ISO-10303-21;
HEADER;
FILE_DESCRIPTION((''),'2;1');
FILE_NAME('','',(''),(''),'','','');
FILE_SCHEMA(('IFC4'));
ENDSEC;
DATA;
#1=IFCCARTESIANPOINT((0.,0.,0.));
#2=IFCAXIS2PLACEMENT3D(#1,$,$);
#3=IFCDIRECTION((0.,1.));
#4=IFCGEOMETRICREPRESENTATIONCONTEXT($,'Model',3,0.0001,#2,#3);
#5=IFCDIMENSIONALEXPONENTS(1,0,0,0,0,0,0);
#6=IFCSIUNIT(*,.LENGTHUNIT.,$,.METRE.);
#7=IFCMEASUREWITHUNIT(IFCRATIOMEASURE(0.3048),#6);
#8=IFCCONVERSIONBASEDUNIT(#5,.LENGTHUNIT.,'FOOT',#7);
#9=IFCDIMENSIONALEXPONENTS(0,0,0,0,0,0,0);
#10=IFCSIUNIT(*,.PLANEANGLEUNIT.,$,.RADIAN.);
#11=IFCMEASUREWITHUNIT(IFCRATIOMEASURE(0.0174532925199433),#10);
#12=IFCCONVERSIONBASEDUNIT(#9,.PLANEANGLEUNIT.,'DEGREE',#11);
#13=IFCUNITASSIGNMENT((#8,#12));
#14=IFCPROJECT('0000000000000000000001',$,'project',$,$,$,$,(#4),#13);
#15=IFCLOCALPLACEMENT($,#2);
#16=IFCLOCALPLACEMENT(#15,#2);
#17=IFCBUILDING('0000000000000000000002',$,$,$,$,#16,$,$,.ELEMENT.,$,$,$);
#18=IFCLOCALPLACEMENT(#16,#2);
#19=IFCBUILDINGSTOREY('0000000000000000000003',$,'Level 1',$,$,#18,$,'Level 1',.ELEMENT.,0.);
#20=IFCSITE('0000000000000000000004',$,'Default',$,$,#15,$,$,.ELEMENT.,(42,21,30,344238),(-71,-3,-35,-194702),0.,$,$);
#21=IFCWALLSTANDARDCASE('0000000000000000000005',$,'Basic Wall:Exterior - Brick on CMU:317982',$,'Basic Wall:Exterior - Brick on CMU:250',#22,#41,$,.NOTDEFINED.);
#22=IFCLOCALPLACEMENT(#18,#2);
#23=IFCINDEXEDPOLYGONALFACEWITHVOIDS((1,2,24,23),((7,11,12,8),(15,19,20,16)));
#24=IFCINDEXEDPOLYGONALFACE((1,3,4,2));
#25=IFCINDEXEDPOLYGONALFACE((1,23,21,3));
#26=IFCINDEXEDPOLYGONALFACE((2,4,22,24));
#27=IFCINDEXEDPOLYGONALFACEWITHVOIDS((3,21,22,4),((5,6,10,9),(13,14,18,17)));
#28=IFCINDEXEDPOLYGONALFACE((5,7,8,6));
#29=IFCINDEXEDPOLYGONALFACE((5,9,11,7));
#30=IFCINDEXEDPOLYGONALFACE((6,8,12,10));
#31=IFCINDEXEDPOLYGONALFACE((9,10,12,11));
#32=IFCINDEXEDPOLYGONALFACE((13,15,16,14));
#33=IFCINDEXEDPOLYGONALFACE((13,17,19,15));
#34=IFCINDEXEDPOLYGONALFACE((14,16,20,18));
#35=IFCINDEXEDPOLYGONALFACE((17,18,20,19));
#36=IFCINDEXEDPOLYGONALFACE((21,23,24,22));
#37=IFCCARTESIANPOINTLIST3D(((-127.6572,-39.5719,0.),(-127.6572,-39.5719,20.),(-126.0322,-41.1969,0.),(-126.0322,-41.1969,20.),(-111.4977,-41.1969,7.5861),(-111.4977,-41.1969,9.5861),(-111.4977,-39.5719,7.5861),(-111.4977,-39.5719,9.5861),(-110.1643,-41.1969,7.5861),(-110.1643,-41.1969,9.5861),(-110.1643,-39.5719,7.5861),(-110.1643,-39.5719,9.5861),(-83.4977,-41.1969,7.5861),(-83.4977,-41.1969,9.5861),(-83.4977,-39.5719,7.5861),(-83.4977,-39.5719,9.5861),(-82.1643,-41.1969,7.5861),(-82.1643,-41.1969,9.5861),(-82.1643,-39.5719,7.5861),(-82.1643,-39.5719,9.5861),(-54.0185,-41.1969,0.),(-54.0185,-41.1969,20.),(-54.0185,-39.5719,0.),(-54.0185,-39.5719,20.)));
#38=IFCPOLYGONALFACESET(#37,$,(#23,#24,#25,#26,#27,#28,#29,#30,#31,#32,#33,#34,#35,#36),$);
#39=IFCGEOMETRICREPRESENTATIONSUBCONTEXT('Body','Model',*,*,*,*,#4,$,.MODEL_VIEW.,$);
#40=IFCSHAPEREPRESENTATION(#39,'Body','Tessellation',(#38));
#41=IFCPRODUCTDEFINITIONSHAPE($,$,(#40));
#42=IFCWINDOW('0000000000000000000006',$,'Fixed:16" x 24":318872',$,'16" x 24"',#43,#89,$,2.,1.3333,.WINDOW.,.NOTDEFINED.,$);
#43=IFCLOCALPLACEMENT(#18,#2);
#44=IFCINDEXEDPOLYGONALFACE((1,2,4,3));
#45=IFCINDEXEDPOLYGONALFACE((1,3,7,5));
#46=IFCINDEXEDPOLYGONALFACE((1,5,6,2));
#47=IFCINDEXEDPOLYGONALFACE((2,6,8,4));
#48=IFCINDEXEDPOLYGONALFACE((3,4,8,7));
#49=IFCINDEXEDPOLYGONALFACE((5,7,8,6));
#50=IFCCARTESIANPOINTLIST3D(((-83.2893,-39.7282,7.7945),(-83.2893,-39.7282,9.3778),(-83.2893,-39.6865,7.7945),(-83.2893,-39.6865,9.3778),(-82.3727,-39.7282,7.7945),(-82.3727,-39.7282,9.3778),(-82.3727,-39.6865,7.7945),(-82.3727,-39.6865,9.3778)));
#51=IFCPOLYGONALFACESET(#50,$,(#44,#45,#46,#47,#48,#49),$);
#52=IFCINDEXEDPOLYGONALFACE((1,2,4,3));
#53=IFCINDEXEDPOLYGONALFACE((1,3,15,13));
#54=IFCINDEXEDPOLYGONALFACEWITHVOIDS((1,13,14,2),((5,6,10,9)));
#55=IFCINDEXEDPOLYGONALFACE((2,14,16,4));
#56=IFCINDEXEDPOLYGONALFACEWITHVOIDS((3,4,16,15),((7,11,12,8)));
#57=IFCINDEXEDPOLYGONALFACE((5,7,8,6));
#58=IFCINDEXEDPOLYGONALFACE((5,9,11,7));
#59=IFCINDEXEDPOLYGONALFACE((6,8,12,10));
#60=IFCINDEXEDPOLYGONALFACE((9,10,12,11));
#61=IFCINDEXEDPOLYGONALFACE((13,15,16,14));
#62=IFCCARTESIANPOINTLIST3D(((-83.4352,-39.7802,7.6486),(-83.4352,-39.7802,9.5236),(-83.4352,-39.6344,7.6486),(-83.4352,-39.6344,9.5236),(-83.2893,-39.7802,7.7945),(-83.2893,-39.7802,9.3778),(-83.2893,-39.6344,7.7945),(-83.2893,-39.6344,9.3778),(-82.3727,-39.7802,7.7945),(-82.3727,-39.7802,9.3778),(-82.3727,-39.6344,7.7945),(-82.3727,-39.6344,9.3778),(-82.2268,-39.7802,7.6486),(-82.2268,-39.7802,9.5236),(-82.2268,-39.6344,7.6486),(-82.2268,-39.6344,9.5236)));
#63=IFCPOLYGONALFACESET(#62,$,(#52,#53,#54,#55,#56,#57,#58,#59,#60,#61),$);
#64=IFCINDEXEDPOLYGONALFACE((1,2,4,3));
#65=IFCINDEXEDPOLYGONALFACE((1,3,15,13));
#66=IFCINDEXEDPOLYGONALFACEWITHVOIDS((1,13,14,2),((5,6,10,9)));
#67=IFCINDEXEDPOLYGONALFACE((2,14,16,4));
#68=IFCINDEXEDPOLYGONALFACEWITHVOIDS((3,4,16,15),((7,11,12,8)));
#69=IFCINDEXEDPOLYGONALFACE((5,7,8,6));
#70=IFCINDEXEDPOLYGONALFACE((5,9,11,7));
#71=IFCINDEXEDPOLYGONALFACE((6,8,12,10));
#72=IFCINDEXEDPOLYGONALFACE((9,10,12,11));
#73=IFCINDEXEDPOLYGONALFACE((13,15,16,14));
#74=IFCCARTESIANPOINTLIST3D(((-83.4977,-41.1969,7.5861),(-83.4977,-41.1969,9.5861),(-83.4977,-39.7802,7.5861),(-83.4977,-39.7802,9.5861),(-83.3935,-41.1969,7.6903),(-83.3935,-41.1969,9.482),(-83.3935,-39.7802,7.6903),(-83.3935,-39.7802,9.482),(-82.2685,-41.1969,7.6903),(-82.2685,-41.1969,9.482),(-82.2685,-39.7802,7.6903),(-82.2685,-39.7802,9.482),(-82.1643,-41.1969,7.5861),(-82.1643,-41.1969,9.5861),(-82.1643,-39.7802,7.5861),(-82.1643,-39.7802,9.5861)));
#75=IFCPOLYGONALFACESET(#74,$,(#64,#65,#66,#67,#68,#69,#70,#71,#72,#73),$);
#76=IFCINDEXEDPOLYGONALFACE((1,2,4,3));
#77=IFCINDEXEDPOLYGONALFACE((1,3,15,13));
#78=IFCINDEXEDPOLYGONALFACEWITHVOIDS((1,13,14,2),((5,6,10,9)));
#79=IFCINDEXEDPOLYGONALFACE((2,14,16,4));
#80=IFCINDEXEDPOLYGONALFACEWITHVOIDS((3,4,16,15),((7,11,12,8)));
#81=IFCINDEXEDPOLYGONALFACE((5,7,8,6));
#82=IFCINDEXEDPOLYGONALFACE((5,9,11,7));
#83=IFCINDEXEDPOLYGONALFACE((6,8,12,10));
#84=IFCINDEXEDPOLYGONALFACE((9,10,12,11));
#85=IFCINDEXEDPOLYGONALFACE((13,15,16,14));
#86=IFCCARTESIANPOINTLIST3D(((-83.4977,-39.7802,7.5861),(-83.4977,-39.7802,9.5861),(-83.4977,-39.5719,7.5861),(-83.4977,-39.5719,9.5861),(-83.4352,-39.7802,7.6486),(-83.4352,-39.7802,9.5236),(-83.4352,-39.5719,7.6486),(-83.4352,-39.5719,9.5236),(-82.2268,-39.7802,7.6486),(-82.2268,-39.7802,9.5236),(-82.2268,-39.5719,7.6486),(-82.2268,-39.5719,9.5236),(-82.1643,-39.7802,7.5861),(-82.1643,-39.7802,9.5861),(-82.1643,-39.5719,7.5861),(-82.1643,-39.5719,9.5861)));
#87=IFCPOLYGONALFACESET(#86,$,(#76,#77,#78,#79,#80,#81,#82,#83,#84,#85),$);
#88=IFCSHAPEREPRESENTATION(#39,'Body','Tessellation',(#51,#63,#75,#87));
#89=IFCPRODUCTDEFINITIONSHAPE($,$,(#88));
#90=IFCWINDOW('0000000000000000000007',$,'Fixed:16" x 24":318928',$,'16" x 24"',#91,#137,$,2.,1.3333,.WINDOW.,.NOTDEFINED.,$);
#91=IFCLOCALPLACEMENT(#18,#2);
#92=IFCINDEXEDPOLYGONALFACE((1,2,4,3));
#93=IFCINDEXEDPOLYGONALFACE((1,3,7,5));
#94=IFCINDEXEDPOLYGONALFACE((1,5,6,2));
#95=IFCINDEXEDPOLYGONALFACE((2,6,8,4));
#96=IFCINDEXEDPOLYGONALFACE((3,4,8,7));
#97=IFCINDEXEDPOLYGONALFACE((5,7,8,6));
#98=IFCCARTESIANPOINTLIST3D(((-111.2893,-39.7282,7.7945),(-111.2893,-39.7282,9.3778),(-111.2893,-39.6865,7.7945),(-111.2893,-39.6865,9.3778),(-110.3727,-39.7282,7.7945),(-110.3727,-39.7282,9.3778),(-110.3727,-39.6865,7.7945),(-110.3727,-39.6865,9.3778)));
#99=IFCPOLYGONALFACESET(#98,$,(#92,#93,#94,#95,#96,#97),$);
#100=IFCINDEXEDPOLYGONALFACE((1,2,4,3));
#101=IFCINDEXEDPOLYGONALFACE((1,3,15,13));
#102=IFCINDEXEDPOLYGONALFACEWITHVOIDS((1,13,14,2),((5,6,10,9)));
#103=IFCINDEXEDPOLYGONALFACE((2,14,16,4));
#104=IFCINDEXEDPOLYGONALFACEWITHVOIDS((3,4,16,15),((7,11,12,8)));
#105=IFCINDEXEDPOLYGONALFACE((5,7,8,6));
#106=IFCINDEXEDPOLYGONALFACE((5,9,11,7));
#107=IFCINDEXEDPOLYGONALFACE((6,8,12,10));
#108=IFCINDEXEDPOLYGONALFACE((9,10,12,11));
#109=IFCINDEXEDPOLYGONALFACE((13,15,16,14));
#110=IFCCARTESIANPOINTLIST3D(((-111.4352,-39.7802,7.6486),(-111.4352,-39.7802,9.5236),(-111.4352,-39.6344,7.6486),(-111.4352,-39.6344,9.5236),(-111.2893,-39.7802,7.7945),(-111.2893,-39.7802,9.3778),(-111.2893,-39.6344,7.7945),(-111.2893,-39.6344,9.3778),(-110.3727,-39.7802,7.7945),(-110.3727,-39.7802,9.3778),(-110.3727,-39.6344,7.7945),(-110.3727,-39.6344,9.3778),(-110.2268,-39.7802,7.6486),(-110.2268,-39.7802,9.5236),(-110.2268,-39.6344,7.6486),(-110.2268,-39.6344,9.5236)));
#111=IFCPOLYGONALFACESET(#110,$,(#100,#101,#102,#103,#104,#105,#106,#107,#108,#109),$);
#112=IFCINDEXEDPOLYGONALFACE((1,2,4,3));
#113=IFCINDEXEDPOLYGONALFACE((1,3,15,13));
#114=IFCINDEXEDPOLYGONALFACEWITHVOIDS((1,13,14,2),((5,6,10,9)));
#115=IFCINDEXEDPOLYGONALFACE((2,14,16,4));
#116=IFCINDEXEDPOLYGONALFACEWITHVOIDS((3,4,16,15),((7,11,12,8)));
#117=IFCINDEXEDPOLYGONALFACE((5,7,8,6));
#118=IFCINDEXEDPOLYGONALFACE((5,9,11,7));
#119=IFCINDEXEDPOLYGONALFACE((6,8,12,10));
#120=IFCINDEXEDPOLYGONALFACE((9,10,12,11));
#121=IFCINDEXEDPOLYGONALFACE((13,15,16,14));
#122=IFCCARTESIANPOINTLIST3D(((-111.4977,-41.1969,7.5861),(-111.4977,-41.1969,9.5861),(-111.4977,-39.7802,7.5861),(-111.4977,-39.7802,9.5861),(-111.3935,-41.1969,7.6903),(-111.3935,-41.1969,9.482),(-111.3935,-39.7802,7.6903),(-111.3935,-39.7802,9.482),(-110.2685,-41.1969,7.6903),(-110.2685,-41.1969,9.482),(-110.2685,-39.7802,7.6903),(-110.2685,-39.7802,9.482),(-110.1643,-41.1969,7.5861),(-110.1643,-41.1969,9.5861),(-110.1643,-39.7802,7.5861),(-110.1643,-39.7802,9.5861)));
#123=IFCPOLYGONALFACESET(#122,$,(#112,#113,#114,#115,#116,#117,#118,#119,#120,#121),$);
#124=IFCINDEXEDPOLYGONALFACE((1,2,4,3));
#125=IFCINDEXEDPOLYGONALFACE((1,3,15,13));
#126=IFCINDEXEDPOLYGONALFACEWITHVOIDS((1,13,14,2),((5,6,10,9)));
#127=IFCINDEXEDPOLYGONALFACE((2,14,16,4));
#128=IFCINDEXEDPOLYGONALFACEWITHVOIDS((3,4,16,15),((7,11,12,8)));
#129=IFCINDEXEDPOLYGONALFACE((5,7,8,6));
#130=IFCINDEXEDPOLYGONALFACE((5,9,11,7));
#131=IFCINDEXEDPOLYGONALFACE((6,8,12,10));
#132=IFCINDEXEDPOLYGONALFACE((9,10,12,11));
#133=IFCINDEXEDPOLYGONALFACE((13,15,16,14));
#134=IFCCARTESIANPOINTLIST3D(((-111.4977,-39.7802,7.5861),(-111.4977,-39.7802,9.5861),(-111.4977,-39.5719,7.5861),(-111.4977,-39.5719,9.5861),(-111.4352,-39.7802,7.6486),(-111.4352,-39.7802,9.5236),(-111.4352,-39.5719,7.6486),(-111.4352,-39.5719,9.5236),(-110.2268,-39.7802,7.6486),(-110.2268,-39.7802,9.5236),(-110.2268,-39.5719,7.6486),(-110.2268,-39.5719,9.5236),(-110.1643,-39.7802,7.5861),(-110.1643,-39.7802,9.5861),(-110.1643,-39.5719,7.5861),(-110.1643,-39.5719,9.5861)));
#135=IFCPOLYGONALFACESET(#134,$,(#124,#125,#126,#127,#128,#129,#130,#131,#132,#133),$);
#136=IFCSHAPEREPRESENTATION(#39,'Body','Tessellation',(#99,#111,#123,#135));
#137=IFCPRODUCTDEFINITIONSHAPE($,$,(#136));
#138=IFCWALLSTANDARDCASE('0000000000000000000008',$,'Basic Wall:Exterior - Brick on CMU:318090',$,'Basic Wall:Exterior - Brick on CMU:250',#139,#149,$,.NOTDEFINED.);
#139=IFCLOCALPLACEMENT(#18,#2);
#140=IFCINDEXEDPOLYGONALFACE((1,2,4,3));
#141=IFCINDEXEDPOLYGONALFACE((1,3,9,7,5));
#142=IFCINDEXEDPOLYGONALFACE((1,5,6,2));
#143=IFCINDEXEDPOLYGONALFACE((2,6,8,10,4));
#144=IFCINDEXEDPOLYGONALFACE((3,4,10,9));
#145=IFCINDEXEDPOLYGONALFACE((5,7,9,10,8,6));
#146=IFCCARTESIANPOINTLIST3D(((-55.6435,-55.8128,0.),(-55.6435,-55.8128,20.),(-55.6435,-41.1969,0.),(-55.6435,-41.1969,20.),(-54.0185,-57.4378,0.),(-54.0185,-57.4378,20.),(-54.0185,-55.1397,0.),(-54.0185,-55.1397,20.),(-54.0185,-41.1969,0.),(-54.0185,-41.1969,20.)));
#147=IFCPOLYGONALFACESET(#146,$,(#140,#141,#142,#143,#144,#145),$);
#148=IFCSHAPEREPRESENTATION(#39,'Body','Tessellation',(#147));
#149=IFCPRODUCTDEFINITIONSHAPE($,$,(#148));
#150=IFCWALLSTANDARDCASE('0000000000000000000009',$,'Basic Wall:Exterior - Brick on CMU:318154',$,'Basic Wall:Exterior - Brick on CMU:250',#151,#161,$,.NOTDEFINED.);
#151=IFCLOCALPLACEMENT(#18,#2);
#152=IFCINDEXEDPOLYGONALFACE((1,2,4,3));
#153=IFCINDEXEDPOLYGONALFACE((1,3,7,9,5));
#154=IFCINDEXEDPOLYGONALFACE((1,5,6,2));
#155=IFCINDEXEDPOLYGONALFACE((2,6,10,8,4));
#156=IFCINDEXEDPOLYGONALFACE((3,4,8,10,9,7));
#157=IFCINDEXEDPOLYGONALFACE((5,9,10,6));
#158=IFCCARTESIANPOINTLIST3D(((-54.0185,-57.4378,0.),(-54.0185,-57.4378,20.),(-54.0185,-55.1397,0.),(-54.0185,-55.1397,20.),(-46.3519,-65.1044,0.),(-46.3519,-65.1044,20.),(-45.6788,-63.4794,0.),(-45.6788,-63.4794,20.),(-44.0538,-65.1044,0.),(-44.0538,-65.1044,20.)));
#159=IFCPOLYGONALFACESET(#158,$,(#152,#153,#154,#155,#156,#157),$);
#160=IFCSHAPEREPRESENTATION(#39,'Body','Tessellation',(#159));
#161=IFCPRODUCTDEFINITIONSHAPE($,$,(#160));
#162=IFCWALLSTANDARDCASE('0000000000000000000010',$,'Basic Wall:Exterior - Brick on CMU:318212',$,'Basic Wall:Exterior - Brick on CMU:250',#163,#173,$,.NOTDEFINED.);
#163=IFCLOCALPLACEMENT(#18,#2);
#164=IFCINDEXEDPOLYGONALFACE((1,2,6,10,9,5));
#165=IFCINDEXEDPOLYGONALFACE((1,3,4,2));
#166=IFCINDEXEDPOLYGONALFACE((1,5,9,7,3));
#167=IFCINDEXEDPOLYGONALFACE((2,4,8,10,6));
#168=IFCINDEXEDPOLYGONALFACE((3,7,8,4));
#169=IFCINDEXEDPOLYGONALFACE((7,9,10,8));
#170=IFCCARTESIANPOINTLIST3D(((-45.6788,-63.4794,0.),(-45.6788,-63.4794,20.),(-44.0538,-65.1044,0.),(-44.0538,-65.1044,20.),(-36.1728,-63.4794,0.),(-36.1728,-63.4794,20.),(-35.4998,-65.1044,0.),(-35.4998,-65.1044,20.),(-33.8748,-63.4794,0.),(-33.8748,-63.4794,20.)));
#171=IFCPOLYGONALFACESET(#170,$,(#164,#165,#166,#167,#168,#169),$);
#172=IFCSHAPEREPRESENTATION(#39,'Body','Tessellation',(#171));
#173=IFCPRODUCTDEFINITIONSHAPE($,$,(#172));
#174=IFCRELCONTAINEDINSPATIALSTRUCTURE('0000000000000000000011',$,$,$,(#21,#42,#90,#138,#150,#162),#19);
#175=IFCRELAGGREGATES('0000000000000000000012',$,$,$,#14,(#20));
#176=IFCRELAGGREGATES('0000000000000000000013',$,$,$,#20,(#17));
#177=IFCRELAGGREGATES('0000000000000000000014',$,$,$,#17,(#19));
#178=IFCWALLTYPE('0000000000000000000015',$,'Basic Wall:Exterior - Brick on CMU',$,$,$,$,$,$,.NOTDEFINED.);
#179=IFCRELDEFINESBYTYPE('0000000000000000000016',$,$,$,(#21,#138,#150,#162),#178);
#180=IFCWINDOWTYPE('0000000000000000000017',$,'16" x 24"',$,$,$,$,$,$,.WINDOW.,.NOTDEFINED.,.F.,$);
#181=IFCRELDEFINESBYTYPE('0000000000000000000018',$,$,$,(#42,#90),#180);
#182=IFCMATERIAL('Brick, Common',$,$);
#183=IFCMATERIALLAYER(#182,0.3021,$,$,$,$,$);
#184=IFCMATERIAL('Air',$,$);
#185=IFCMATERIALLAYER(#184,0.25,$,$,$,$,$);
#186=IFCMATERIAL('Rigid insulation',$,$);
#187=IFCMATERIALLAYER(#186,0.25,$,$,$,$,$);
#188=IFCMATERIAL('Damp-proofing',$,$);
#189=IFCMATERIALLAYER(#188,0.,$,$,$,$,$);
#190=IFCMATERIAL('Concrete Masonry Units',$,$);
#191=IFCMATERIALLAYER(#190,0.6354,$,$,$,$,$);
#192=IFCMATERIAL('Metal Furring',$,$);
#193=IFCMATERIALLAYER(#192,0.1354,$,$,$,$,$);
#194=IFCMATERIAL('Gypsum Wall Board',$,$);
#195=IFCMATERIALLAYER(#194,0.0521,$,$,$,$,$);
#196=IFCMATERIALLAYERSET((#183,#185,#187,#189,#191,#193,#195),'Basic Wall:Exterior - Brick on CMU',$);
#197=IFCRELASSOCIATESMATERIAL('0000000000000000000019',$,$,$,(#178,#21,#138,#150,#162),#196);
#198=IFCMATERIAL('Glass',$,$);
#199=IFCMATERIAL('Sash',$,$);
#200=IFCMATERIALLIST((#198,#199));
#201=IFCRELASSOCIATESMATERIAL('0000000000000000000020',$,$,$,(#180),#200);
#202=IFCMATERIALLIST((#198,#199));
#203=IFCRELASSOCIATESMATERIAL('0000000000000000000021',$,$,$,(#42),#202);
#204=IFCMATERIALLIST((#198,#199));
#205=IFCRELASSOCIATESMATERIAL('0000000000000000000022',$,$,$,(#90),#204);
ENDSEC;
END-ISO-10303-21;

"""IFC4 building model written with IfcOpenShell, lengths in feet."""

from ifc_helpers import new_model, entity, si_unit, converted_unit, direction, frame, frame_2d, origin, place, context, subcontext, project, spatial, polyline, rectangle, outline, extrude, source, transform, mapped, material, material_list, layer, layer_set, layer_usage, type_object, type_shapes, element, fill, save


model = new_model("IFC4")

# Units and contexts
model_context = context("Model", 3, precision=0.0001, world=origin(), true_north=direction((0.0, 1.0)))
body_context = subcontext(model_context, "Body", "Model", "MODEL_VIEW")
ifc_project = project(units=[converted_unit("LENGTHUNIT", "FOOT", entity("IfcRatioMeasure", 0.3048), si_unit("LENGTHUNIT", "METRE"), dimensions=[1, 0, 0, 0, 0, 0, 0]), converted_unit("PLANEANGLEUNIT", "DEGREE", entity("IfcRatioMeasure", 0.0174532925199433), si_unit("PLANEANGLEUNIT", "RADIAN"), dimensions=[0, 0, 0, 0, 0, 0, 0])], contexts=[model_context])

# Site, building, storey
site_placement = place(None, origin())
site = spatial("IfcSite", under=ifc_project, at=site_placement, Name="Default", CompositionType="ELEMENT", RefLatitude=(42, 21, 30, 344238), RefLongitude=(-71, -3, -35, -194702), RefElevation=0.0)
building_placement = place(site_placement, origin())
building = spatial("IfcBuilding", under=site, at=building_placement, CompositionType="ELEMENT")
storey_placement = place(building_placement, origin())
storey = spatial("IfcBuildingStorey", under=building, at=storey_placement, Name="Level 1", LongName="Level 1", CompositionType="ELEMENT", Elevation=0.0)

# Shared definitions
ifc_material_1 = material(Name="Brick, Common")
ifc_layer_1 = layer(ifc_material_1, 0.3021)
ifc_material_2 = material(Name="Air")
ifc_layer_2 = layer(ifc_material_2, 0.25)
ifc_material_3 = material(Name="Rigid insulation")
ifc_layer_3 = layer(ifc_material_3, 0.25)
ifc_material_4 = material(Name="Damp-proofing")
ifc_layer_4 = layer(ifc_material_4, 0.0)
ifc_material_5 = material(Name="Concrete Masonry Units")
ifc_layer_5 = layer(ifc_material_5, 0.6354)
ifc_material_6 = material(Name="Metal Furring")
ifc_layer_6 = layer(ifc_material_6, 0.1354)
ifc_material_7 = material(Name="Gypsum Wall Board")
ifc_layer_7 = layer(ifc_material_7, 0.0521)
ifc_layer_set = layer_set([ifc_layer_1, ifc_layer_2, ifc_layer_3, ifc_layer_4, ifc_layer_5, ifc_layer_6, ifc_layer_7], Name="Basic Wall:Exterior - Brick on CMU")
wall_type = type_object("IfcWallType", Name="Basic Wall:Exterior - Brick on CMU", PredefinedType="NOTDEFINED", material=ifc_layer_set)
ifc_material_8 = material(Name="Glass")
ifc_material_9 = material(Name="Sash")
ifc_material_list_1 = material_list([ifc_material_8, ifc_material_9])
window_type = type_object("IfcWindowType", Name="16\" x 24\"", ParameterTakesPrecedence=False, PartitioningType="NOTDEFINED", PredefinedType="WINDOW", material=ifc_material_list_1)
shared_shape_1 = source(origin(), body_context, "Body", "SweptSolid", [
    extrude(rectangle(XDim=0.0417, YDim=0.9167, at=frame_2d((0.0, 0.0), x_axis=(1.0, 0.0))), frame((0.6667, 1.4896, 0.2083), z_axis=(0.0, 0.0, 1.0), x_axis=(0.0, 1.0, 0.0)), (0.0, 0.0, 1.0), 1.5833),
    extrude(outline(polyline([(-0.6042, -0.9375), (0.6042, -0.9375), (0.6042, 0.9375), (-0.6042, 0.9375), (-0.6042, -0.9375)]), holes=[polyline([(-0.4583, -0.7917), (-0.4583, 0.7917), (0.4583, 0.7917), (0.4583, -0.7917), (-0.4583, -0.7917)])]), frame((0.6667, 1.4167, 1.0), z_axis=(0.0, 1.0, 0.0), x_axis=(1.0, 0.0, 0.0)), (0.0, 0.0, 1.0), 0.1458),
    extrude(outline(polyline([(-0.6667, -1.0), (0.6667, -1.0), (0.6667, 1.0), (-0.6667, 1.0), (-0.6667, -1.0)]), holes=[polyline([(-0.5625, -0.8958), (-0.5625, 0.8958), (0.5625, 0.8958), (0.5625, -0.8958), (-0.5625, -0.8958)])]), frame((0.6667, 0.0, 1.0), z_axis=(0.0, 1.0, 0.0), x_axis=(1.0, 0.0, 0.0)), (0.0, 0.0, 1.0), 1.4167),
    extrude(outline(polyline([(-1.0, -0.6667), (1.0, -0.6667), (1.0, 0.6667), (-1.0, 0.6667), (-1.0, -0.6667)]), holes=[polyline([(-0.9375, -0.6042), (-0.9375, 0.6042), (0.9375, 0.6042), (0.9375, -0.6042), (-0.9375, -0.6042)])]), frame((0.6667, 1.4167, 1.0), z_axis=(0.0, 1.0, 0.0), x_axis=(0.0, 0.0, -1.0)), (0.0, 0.0, 1.0), 0.2083),
])
type_shapes(window_type, [shared_shape_1])

# Wall, openings, windows
ifc_layer_usage_1 = layer_usage(ifc_layer_set, "AXIS2", "NEGATIVE", 0.8125)
wall_1_placement = place(storey_placement, frame((-127.6572, -40.3844, 0.0)))
wall_1 = element("IfcWallStandardCase", 1, at=wall_1_placement, inside=storey, type_object=wall_type, material=ifc_layer_usage_1, Name="Basic Wall:Exterior - Brick on CMU:317982", ObjectType="Basic Wall:Exterior - Brick on CMU:250", PredefinedType="NOTDEFINED", context=body_context, shape_type="SweptSolid", body=[
    extrude(outline(polyline([(73.6387, -0.8125), (73.6387, 0.8125), (0.0, 0.8125), (1.625, -0.8125), (72.0137, -0.8125), (73.6387, -0.8125)])), origin(), (0.0, 0.0, 1.0), 20.0),
])
opening_1_placement = place(wall_1_placement, frame((44.1595, -0.8125, 7.5861)))
opening_1 = element("IfcOpeningElement", 2, at=opening_1_placement, cuts=wall_1, ObjectType="Opening", PredefinedType="OPENING", context=body_context, shape_type="SweptSolid", body=[
    extrude(rectangle(XDim=2.0, YDim=1.3333, at=frame_2d((1.0, 0.6667), x_axis=(-1.0, 0.0))), frame((0.0, 0.0, 0.0), z_axis=(0.0, 1.0, 0.0), x_axis=(0.0, 0.0, 1.0)), (0.0, 0.0, 1.0), 1.625),
])
opening_2_placement = place(wall_1_placement, frame((16.1595, -0.8125, 7.5861)))
opening_2 = element("IfcOpeningElement", 3, at=opening_2_placement, cuts=wall_1, ObjectType="Opening", PredefinedType="OPENING", context=body_context, shape_type="SweptSolid", body=[
    extrude(rectangle(XDim=2.0, YDim=1.3333, at=frame_2d((1.0, 0.6667), x_axis=(-1.0, 0.0))), frame((0.0, 0.0, 0.0), z_axis=(0.0, 1.0, 0.0), x_axis=(0.0, 0.0, 1.0)), (0.0, 0.0, 1.0), 1.625),
])
ifc_material_list_2 = material_list([ifc_material_8, ifc_material_9])
window_1_placement = place(opening_1_placement, origin())
window_1 = element("IfcWindow", 4, at=window_1_placement, inside=storey, type_object=window_type, material=ifc_material_list_2, Name="Fixed:16\" x 24\":318872", ObjectType="16\" x 24\"", OverallHeight=2.0, OverallWidth=1.3333, PartitioningType="NOTDEFINED", PredefinedType="WINDOW", context=body_context, shape_type="MappedRepresentation", body=[
    mapped(shared_shape_1, transform((0.0, 0.0, 0.0), scale=1.0)),
])
fill(opening_1, window_1)
ifc_material_list_3 = material_list([ifc_material_8, ifc_material_9])
window_2_placement = place(opening_2_placement, origin())
window_2 = element("IfcWindow", 5, at=window_2_placement, inside=storey, type_object=window_type, material=ifc_material_list_3, Name="Fixed:16\" x 24\":318928", ObjectType="16\" x 24\"", OverallHeight=2.0, OverallWidth=1.3333, PartitioningType="NOTDEFINED", PredefinedType="WINDOW", context=body_context, shape_type="MappedRepresentation", body=[
    mapped(shared_shape_1, transform((0.0, 0.0, 0.0), scale=1.0)),
])
fill(opening_2, window_2)

# Walls
ifc_layer_usage_2 = layer_usage(ifc_layer_set, "AXIS2", "NEGATIVE", 0.8125)
wall_2_placement = place(storey_placement, frame((-54.831, -41.1969, 0.0), z_axis=(0.0, 0.0, 1.0), x_axis=(0.0, -1.0, 0.0)))
element("IfcWallStandardCase", 6, at=wall_2_placement, inside=storey, type_object=wall_type, material=ifc_layer_usage_2, Name="Basic Wall:Exterior - Brick on CMU:318090", ObjectType="Basic Wall:Exterior - Brick on CMU:250", PredefinedType="NOTDEFINED", context=body_context, shape_type="SweptSolid", body=[
    extrude(outline(polyline([(14.6159, -0.8125), (16.2409, 0.8125), (13.9428, 0.8125), (0.0, 0.8125), (0.0, -0.8125), (14.6159, -0.8125)])), origin(), (0.0, 0.0, 1.0), 20.0),
])
ifc_layer_usage_3 = layer_usage(ifc_layer_set, "AXIS2", "NEGATIVE", 0.8125)
wall_3_placement = place(storey_placement, frame((-54.593, -55.7142, 0.0), z_axis=(0.0, 0.0, 1.0), x_axis=(0.707107, -0.707107, 0.0)))
element("IfcWallStandardCase", 7, at=wall_3_placement, inside=storey, type_object=wall_type, material=ifc_layer_usage_3, Name="Basic Wall:Exterior - Brick on CMU:318154", ObjectType="Basic Wall:Exterior - Brick on CMU:250", PredefinedType="NOTDEFINED", context=body_context, shape_type="SweptSolid", body=[
    extrude(outline(polyline([(12.4672, -0.8125), (14.0922, 0.8125), (11.7941, 0.8125), (0.0, 0.8125), (1.625, -0.8125), (12.4672, -0.8125)])), origin(), (0.0, 0.0, 1.0), 20.0),
])
ifc_layer_usage_4 = layer_usage(ifc_layer_set, "AXIS2", "NEGATIVE", 0.8125)
wall_4_placement = place(storey_placement, frame((-45.6788, -64.2919, 0.0)))
element("IfcWallStandardCase", 8, at=wall_4_placement, inside=storey, type_object=wall_type, material=ifc_layer_usage_4, Name="Basic Wall:Exterior - Brick on CMU:318212", ObjectType="Basic Wall:Exterior - Brick on CMU:250", PredefinedType="NOTDEFINED", context=body_context, shape_type="SweptSolid", body=[
    extrude(outline(polyline([(10.1791, -0.8125), (11.8041, 0.8125), (9.506, 0.8125), (0.0, 0.8125), (1.625, -0.8125), (10.1791, -0.8125)])), origin(), (0.0, 0.0, 1.0), 20.0),
])

save(model, "model.ifc")
